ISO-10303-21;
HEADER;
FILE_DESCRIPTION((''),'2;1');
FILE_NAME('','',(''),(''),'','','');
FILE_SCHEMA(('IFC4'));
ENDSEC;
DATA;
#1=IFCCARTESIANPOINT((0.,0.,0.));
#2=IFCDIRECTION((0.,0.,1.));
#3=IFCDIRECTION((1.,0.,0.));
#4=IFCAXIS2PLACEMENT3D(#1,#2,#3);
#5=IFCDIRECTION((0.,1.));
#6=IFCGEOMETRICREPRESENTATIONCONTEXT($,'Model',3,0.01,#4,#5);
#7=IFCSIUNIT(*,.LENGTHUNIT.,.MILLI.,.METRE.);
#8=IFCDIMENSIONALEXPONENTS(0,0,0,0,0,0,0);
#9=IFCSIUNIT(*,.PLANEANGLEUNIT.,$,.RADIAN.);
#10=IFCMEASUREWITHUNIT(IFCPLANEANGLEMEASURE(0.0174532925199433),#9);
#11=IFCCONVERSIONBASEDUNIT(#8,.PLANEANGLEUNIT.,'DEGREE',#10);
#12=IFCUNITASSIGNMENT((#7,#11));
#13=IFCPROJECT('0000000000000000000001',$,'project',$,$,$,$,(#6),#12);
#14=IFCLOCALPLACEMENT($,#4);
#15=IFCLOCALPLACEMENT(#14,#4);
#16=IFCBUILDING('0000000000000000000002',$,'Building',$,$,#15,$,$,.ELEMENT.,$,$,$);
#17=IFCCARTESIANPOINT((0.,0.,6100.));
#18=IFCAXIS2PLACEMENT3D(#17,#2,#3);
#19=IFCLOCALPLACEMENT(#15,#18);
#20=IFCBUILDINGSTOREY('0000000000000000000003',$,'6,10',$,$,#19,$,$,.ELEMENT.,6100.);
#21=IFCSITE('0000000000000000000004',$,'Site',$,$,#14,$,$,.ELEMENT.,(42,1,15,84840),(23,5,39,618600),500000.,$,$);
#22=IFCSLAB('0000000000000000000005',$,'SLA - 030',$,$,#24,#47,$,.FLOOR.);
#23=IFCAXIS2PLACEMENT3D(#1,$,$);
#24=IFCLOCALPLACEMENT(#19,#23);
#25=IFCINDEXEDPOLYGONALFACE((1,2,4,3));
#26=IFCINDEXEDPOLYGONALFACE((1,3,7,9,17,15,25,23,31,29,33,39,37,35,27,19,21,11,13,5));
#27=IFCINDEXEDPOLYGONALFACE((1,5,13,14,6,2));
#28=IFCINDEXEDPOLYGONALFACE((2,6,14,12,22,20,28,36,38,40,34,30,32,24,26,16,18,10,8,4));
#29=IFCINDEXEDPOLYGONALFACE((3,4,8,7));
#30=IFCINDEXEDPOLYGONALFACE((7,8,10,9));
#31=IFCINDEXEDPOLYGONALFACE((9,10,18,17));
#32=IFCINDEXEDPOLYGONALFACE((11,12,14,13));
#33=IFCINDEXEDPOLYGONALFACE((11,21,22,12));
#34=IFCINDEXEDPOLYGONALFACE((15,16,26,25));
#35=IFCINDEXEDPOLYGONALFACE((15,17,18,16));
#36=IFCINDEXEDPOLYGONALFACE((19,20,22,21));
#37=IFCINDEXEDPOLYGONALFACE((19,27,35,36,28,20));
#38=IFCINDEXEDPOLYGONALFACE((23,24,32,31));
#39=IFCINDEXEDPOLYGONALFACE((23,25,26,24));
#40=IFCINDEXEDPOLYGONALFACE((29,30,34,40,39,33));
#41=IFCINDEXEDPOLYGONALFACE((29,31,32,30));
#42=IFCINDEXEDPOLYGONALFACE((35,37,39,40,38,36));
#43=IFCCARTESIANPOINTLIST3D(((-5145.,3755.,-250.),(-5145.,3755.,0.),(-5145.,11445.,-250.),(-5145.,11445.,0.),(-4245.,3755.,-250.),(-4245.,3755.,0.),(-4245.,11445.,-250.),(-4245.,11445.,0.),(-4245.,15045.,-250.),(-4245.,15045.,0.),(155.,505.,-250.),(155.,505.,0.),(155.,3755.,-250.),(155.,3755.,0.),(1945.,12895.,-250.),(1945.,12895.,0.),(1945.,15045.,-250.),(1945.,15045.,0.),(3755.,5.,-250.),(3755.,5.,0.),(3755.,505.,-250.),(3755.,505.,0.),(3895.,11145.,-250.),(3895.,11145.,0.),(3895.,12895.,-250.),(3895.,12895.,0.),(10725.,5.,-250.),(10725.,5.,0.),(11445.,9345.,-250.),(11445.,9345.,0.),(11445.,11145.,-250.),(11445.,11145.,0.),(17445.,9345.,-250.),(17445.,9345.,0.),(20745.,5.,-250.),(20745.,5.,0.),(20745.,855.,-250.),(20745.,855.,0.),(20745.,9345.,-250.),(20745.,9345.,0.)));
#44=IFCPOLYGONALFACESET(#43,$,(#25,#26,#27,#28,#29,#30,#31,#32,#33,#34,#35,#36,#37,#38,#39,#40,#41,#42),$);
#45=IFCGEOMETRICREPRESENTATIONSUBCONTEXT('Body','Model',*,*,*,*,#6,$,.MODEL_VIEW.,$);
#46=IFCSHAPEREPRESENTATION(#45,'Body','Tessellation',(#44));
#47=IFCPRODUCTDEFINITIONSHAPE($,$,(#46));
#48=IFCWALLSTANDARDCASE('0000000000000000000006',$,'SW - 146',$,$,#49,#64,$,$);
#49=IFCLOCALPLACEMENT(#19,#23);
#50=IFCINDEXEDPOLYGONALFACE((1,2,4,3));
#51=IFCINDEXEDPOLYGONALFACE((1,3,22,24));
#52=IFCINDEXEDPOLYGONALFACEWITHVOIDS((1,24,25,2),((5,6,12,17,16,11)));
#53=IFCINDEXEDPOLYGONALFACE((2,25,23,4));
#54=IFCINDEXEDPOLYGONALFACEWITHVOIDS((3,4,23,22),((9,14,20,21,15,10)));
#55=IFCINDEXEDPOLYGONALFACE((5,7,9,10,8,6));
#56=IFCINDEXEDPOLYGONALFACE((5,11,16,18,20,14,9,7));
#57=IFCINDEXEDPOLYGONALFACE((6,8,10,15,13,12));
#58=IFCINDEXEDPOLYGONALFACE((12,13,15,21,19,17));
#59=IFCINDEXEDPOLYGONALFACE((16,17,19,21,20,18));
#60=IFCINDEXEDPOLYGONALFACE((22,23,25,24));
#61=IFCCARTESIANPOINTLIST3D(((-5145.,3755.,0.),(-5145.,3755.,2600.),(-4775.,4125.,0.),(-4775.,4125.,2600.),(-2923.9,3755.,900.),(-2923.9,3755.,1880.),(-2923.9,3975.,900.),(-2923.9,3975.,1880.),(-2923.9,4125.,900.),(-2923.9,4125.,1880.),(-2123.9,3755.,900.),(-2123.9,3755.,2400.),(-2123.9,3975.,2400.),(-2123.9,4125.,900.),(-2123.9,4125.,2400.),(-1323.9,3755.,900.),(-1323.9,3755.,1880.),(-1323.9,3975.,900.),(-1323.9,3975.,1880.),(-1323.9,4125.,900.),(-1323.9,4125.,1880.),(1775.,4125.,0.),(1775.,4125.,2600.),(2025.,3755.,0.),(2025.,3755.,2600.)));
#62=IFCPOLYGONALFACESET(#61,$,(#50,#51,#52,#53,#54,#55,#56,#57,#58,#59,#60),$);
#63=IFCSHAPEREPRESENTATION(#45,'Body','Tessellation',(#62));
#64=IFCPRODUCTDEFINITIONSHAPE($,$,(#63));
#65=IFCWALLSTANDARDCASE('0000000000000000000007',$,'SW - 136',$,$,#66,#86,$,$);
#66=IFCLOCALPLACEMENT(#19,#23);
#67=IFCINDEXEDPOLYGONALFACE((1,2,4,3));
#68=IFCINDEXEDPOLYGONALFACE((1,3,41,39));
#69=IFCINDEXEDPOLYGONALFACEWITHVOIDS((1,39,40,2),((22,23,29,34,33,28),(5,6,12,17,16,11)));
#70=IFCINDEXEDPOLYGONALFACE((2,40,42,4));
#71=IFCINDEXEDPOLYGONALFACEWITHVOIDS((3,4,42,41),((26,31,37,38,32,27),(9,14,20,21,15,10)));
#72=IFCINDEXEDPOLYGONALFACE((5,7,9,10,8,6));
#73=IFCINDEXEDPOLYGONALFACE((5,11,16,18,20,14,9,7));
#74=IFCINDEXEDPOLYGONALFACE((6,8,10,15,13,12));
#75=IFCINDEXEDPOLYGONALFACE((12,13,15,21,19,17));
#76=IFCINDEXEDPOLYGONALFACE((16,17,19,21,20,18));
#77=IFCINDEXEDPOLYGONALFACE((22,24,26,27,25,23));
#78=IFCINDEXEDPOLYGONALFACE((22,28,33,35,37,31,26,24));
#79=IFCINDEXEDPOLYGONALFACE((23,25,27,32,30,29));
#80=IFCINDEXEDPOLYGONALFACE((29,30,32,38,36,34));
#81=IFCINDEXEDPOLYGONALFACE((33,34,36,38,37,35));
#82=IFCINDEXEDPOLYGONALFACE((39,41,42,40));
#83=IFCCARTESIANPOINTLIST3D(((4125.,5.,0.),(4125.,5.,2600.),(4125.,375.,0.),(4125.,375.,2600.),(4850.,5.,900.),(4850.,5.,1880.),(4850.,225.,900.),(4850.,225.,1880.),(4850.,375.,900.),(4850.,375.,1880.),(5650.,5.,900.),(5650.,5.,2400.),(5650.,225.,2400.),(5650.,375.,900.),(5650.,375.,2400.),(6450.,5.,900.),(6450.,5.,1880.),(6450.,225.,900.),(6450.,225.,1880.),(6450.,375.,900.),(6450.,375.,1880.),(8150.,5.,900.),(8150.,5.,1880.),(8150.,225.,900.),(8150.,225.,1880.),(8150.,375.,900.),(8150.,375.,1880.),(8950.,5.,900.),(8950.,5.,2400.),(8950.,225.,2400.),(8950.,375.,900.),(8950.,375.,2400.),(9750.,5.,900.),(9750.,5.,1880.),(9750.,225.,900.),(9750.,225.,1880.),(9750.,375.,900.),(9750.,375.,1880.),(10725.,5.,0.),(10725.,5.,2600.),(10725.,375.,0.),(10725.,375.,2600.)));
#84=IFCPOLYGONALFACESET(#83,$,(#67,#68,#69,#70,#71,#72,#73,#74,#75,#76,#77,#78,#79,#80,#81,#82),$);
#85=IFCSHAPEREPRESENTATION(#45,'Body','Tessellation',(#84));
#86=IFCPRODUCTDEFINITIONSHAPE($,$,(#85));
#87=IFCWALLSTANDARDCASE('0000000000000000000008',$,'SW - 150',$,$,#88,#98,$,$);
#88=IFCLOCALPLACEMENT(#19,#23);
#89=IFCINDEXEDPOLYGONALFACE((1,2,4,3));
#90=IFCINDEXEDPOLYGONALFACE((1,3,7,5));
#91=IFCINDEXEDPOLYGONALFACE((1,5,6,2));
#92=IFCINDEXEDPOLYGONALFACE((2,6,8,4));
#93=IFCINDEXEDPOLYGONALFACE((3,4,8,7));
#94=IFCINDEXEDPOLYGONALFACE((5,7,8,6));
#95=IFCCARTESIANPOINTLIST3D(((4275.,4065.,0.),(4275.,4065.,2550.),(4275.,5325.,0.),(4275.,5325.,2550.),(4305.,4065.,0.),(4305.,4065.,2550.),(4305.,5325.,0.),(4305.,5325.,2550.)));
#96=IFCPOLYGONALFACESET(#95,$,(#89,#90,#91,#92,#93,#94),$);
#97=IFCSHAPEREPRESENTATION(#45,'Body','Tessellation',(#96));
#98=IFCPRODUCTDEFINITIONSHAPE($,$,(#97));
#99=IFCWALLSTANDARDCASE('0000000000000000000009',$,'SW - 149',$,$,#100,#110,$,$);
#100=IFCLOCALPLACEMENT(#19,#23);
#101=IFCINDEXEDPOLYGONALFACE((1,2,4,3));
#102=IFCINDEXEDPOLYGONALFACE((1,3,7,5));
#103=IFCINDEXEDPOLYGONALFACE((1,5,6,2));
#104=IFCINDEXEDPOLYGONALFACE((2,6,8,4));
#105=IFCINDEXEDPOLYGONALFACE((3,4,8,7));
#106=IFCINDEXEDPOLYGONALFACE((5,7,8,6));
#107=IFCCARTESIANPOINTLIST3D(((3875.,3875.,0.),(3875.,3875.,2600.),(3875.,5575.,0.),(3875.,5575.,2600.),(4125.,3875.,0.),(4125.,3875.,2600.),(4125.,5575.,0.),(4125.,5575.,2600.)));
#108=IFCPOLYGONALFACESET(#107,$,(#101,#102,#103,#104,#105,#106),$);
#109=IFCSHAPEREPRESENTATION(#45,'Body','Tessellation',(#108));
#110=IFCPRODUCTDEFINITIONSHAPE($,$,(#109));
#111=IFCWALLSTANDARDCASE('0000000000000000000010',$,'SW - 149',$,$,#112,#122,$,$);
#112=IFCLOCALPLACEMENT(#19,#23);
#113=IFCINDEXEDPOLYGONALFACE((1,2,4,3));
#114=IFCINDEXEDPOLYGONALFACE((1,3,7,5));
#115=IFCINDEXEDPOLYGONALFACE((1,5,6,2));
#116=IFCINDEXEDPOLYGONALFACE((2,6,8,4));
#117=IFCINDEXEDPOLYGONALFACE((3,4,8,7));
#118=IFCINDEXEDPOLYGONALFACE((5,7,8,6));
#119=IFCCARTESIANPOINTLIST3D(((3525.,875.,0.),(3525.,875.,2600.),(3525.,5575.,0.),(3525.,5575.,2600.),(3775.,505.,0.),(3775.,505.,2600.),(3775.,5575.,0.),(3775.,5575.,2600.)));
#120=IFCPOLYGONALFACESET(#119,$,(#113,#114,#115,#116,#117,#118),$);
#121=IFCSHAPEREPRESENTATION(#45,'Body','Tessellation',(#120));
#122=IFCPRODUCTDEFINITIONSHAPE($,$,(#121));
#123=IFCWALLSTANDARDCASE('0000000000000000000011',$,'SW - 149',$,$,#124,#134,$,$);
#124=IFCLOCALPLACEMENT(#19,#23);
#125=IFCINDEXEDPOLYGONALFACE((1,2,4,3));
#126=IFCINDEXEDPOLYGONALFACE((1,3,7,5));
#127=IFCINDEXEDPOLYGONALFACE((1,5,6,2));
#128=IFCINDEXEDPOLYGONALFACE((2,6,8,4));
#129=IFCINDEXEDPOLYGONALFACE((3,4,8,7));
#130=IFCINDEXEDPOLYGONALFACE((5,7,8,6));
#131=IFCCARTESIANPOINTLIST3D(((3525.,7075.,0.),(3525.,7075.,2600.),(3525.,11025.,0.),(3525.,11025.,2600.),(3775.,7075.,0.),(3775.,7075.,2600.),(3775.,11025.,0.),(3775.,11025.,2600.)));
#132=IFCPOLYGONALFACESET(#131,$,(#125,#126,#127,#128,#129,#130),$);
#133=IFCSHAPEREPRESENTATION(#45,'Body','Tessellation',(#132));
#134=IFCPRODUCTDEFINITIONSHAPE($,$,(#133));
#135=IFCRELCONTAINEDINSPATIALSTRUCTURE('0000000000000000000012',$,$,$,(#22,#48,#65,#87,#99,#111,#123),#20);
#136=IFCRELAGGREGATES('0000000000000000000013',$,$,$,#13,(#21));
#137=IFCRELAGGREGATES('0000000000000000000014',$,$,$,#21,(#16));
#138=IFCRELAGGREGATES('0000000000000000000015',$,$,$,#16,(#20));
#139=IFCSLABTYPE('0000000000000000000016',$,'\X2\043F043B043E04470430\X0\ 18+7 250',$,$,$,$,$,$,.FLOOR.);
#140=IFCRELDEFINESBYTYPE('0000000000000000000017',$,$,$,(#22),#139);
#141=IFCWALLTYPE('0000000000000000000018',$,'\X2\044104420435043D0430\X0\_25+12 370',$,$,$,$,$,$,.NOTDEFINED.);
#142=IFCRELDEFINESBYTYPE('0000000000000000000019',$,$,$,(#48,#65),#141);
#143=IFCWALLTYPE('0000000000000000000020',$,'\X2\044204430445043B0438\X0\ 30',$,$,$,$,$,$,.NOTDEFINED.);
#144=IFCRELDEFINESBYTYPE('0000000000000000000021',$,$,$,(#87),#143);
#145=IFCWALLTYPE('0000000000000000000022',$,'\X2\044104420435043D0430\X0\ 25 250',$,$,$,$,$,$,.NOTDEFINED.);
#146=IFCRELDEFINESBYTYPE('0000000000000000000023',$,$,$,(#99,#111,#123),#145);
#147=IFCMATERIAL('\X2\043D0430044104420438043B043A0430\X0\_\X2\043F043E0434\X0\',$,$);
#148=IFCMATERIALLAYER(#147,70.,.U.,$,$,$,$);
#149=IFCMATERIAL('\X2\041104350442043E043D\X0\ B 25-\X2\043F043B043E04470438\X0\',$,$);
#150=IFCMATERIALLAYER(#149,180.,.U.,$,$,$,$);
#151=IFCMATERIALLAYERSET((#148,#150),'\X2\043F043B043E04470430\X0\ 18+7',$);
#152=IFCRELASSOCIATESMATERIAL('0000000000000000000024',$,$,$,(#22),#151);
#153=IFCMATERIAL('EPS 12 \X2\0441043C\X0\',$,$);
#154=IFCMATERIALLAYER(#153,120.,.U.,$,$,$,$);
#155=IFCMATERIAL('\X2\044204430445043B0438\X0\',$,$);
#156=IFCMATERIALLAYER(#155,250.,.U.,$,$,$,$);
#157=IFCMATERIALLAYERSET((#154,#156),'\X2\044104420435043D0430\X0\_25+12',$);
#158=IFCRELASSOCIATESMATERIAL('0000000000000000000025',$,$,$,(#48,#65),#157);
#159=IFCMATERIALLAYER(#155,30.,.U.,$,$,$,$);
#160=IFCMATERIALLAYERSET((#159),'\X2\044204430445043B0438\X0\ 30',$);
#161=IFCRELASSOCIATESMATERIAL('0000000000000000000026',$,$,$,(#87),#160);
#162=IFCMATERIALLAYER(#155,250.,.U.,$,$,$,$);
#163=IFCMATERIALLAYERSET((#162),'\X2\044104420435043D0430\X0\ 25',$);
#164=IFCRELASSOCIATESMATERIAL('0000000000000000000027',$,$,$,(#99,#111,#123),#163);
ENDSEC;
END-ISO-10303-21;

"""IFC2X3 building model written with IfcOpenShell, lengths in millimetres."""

from ifc_helpers import new_model, entity, si_unit, converted_unit, direction, frame, origin_with_axes, place, context, subcontext, project, spatial, polyline, outline, extrude, material, layer, layer_set, layer_usage, type_object, element, save


model = new_model("IFC2X3")

# Units and contexts
model_context = context("Model", 3, precision=0.01, world=origin_with_axes(), true_north=direction((0.0, 1.0)))
body_context = subcontext(model_context, "Body", "Model", "MODEL_VIEW")
ifc_project = project(units=[si_unit("LENGTHUNIT", "METRE", prefix="MILLI"), converted_unit("PLANEANGLEUNIT", "DEGREE", entity("IfcPlaneAngleMeasure", 0.0174532925199433), si_unit("PLANEANGLEUNIT", "RADIAN"), dimensions=[0, 0, 0, 0, 0, 0, 0])], contexts=[model_context])

# Site, building, storey
site_placement = place(None, origin_with_axes())
site = spatial("IfcSite", under=ifc_project, at=site_placement, Name="Site", CompositionType="ELEMENT", RefLatitude=(42, 1, 15, 84840), RefLongitude=(23, 5, 39, 618600), RefElevation=500000.0)
building_placement = place(site_placement, origin_with_axes())
building = spatial("IfcBuilding", under=site, at=building_placement, Name="Building", CompositionType="ELEMENT")
storey_placement = place(building_placement, frame((0.0, 0.0, 6100.0), z_axis=(0.0, 0.0, 1.0), x_axis=(1.0, 0.0, 0.0)))
storey = spatial("IfcBuildingStorey", under=building, at=storey_placement, Name="6,10", CompositionType="ELEMENT", Elevation=6100.0)

# Slab
ifc_material_1 = material(Name="настилка_под")
ifc_layer_1 = layer(ifc_material_1, 70.0, ventilated="UNKNOWN")
ifc_material_2 = material(Name="Бетон B 25-плочи")
ifc_layer_2 = layer(ifc_material_2, 180.0, ventilated="UNKNOWN")
ifc_layer_set_1 = layer_set([ifc_layer_1, ifc_layer_2], Name="плоча 18+7")
ifc_layer_usage_1 = layer_usage(ifc_layer_set_1, "AXIS3", "NEGATIVE", 250.0)
slab_type_1 = type_object("IfcSlabType", Name="плоча 18+7 250", PredefinedType="FLOOR")
slab_1_placement = place(storey_placement, frame((-5145.0, 3755.0, 0.0), z_axis=(0.0, 0.0, 1.0), x_axis=(1.0, 0.0, 0.0)))
element("IfcSlab", 1, at=slab_1_placement, inside=storey, type_object=slab_type_1, material=ifc_layer_usage_1, Name="SLA - 030", PredefinedType="FLOOR", context=body_context, shape_type="SweptSolid", body=[
    extrude(outline(polyline([(0.0, 0.0), (900.0, 0.0), (5300.0, 0.0), (5300.0, -3250.0), (8900.0, -3250.0), (8900.0, -3750.0), (15870.0, -3750.0), (25890.0, -3750.0), (25890.0, -2900.0), (25890.0, 5590.0), (22590.0, 5590.0), (16590.0, 5590.0), (16590.0, 7390.0), (9040.0, 7390.0), (9040.0, 9140.0), (7090.0, 9140.0), (7090.0, 11290.0), (900.0, 11290.0), (900.0, 7690.0), (0.0, 7690.0), (0.0, 0.0)])), frame((0.0, 0.0, -250.0), z_axis=(0.0, 0.0, 1.0), x_axis=(1.0, 0.0, 0.0)), (0.0, 0.0, 1.0), 250.0),
])

# Walls, openings
ifc_material_3 = material(Name="EPS 12 см")
ifc_layer_3 = layer(ifc_material_3, 120.0, ventilated="UNKNOWN")
ifc_material_4 = material(Name="тухли")
ifc_layer_4 = layer(ifc_material_4, 250.0, ventilated="UNKNOWN")
ifc_layer_set_2 = layer_set([ifc_layer_3, ifc_layer_4], Name="стена_25+12")
ifc_layer_usage_2 = layer_usage(ifc_layer_set_2, "AXIS2", "POSITIVE", -120.0)
wall_type_1 = type_object("IfcWallType", Name="стена_25+12 370", PredefinedType="NOTDEFINED")
wall_1_placement = place(storey_placement, frame((-5025.0, 3875.0, 0.0), z_axis=(0.0, 0.0, 1.0), x_axis=(1.0, 0.0, 0.0)))
wall_1 = element("IfcWallStandardCase", 2, at=wall_1_placement, inside=storey, type_object=wall_type_1, material=ifc_layer_usage_2, Name="SW - 146", context=body_context, shape_type="SweptSolid", body=[
    extrude(outline(polyline([(-120.0, -120.0), (7050.0, -120.0), (6800.0, 250.0), (250.0, 250.0), (-120.0, -120.0)])), origin_with_axes(), (0.0, 0.0, 1.0), 2600.0),
])
opening_1_placement = place(wall_1_placement, frame((2501.1, 0.0, 900.0), z_axis=(0.0, 0.0, 1.0), x_axis=(1.0, 0.0, 0.0)))
element("IfcOpeningElement", 3, at=opening_1_placement, cuts=wall_1, context=body_context, shape_type="SweptSolid", body=[
    extrude(outline(polyline([(-400.0, 0.0), (-400.0, -1500.0), (400.0, -980.0), (400.0, 0.0), (-400.0, 0.0)])), frame((0.0, 100.0, 0.0), z_axis=(0.0, -1.0, 0.0), x_axis=(-1.0, 0.0, 0.0)), (0.0, 0.0, 1.0), 590.0),
    extrude(outline(polyline([(400.0, 0.0), (400.0, 980.0), (-400.0, 1500.0), (-400.0, 0.0), (400.0, 0.0)])), frame((0.0, 100.0, 0.0), z_axis=(0.0, 1.0, 0.0), x_axis=(-1.0, 0.0, 0.0)), (0.0, 0.0, 1.0), 520.0),
])
opening_2_placement = place(wall_1_placement, frame((3301.1, 0.0, 900.0), z_axis=(0.0, 0.0, 1.0), x_axis=(1.0, 0.0, 0.0)))
element("IfcOpeningElement", 4, at=opening_2_placement, cuts=wall_1, context=body_context, shape_type="SweptSolid", body=[
    extrude(outline(polyline([(-400.0, 0.0), (-400.0, -1500.0), (400.0, -980.0), (400.0, 0.0), (-400.0, 0.0)])), frame((0.0, 100.0, 0.0), z_axis=(0.0, 1.0, 0.0), x_axis=(1.0, 0.0, 0.0)), (0.0, 0.0, -1.0), 590.0),
    extrude(outline(polyline([(400.0, 0.0), (400.0, 980.0), (-400.0, 1500.0), (-400.0, 0.0), (400.0, 0.0)])), frame((0.0, 100.0, 0.0), z_axis=(0.0, -1.0, 0.0), x_axis=(1.0, 0.0, 0.0)), (0.0, 0.0, -1.0), 520.0),
])
ifc_layer_usage_3 = layer_usage(ifc_layer_set_2, "AXIS2", "POSITIVE", -120.0)
wall_2_placement = place(storey_placement, frame((3875.0, 125.0, 0.0), z_axis=(0.0, 0.0, 1.0), x_axis=(1.0, 0.0, 0.0)))
wall_2 = element("IfcWallStandardCase", 5, at=wall_2_placement, inside=storey, type_object=wall_type_1, material=ifc_layer_usage_3, Name="SW - 136", context=body_context, shape_type="SweptSolid", body=[
    extrude(outline(polyline([(250.0, -120.0), (6850.0, -120.0), (6850.0, 250.0), (250.0, 250.0), (250.0, -120.0)])), origin_with_axes(), (0.0, 0.0, 1.0), 2600.0),
])
opening_3_placement = place(wall_2_placement, frame((1375.0, 0.0, 900.0), z_axis=(0.0, 0.0, 1.0), x_axis=(1.0, 0.0, 0.0)))
element("IfcOpeningElement", 6, at=opening_3_placement, cuts=wall_2, context=body_context, shape_type="SweptSolid", body=[
    extrude(outline(polyline([(-400.0, 0.0), (-400.0, -1500.0), (400.0, -980.0), (400.0, 0.0), (-400.0, 0.0)])), frame((0.0, 100.0, 0.0), z_axis=(0.0, -1.0, 0.0), x_axis=(-1.0, 0.0, 0.0)), (0.0, 0.0, 1.0), 590.0),
    extrude(outline(polyline([(400.0, 0.0), (400.0, 980.0), (-400.0, 1500.0), (-400.0, 0.0), (400.0, 0.0)])), frame((0.0, 100.0, 0.0), z_axis=(0.0, 1.0, 0.0), x_axis=(-1.0, 0.0, 0.0)), (0.0, 0.0, 1.0), 520.0),
])
opening_4_placement = place(wall_2_placement, frame((2175.0, 0.0, 900.0), z_axis=(0.0, 0.0, 1.0), x_axis=(1.0, 0.0, 0.0)))
element("IfcOpeningElement", 7, at=opening_4_placement, cuts=wall_2, context=body_context, shape_type="SweptSolid", body=[
    extrude(outline(polyline([(-400.0, 0.0), (-400.0, -1500.0), (400.0, -980.0), (400.0, 0.0), (-400.0, 0.0)])), frame((0.0, 100.0, 0.0), z_axis=(0.0, 1.0, 0.0), x_axis=(1.0, 0.0, 0.0)), (0.0, 0.0, -1.0), 590.0),
    extrude(outline(polyline([(400.0, 0.0), (400.0, 980.0), (-400.0, 1500.0), (-400.0, 0.0), (400.0, 0.0)])), frame((0.0, 100.0, 0.0), z_axis=(0.0, -1.0, 0.0), x_axis=(1.0, 0.0, 0.0)), (0.0, 0.0, -1.0), 520.0),
])
opening_5_placement = place(wall_2_placement, frame((4675.0, 0.0, 900.0), z_axis=(0.0, 0.0, 1.0), x_axis=(1.0, 0.0, 0.0)))
element("IfcOpeningElement", 8, at=opening_5_placement, cuts=wall_2, context=body_context, shape_type="SweptSolid", body=[
    extrude(outline(polyline([(-400.0, 0.0), (-400.0, -1500.0), (400.0, -980.0), (400.0, 0.0), (-400.0, 0.0)])), frame((0.0, 100.0, 0.0), z_axis=(0.0, -1.0, 0.0), x_axis=(-1.0, 0.0, 0.0)), (0.0, 0.0, 1.0), 590.0),
    extrude(outline(polyline([(400.0, 0.0), (400.0, 980.0), (-400.0, 1500.0), (-400.0, 0.0), (400.0, 0.0)])), frame((0.0, 100.0, 0.0), z_axis=(0.0, 1.0, 0.0), x_axis=(-1.0, 0.0, 0.0)), (0.0, 0.0, 1.0), 520.0),
])
opening_6_placement = place(wall_2_placement, frame((5475.0, 0.0, 900.0), z_axis=(0.0, 0.0, 1.0), x_axis=(1.0, 0.0, 0.0)))
element("IfcOpeningElement", 9, at=opening_6_placement, cuts=wall_2, context=body_context, shape_type="SweptSolid", body=[
    extrude(outline(polyline([(-400.0, 0.0), (-400.0, -1500.0), (400.0, -980.0), (400.0, 0.0), (-400.0, 0.0)])), frame((0.0, 100.0, 0.0), z_axis=(0.0, 1.0, 0.0), x_axis=(1.0, 0.0, 0.0)), (0.0, 0.0, -1.0), 590.0),
    extrude(outline(polyline([(400.0, 0.0), (400.0, 980.0), (-400.0, 1500.0), (-400.0, 0.0), (400.0, 0.0)])), frame((0.0, 100.0, 0.0), z_axis=(0.0, -1.0, 0.0), x_axis=(1.0, 0.0, 0.0)), (0.0, 0.0, -1.0), 520.0),
])

# Walls
ifc_layer_5 = layer(ifc_material_4, 30.0, ventilated="UNKNOWN")
ifc_layer_set_3 = layer_set([ifc_layer_5], Name="тухли 30")
wall_type_2 = type_object("IfcWallType", Name="тухли 30", PredefinedType="NOTDEFINED")
ifc_layer_usage_4 = layer_usage(ifc_layer_set_3, "AXIS2", "POSITIVE", 0.0)
wall_3_placement = place(storey_placement, frame((4305.0, 4065.0, 0.0), z_axis=(0.0, 0.0, 1.0), x_axis=(0.0, 1.0, 0.0)))
element("IfcWallStandardCase", 10, at=wall_3_placement, inside=storey, type_object=wall_type_2, material=ifc_layer_usage_4, Name="SW - 150", context=body_context, shape_type="SweptSolid", body=[
    extrude(outline(polyline([(0.0, 0.0), (1260.0, 0.0), (1260.0, 30.0), (0.0, 30.0), (0.0, 0.0)])), origin_with_axes(), (0.0, 0.0, 1.0), 2550.0),
])
ifc_layer_6 = layer(ifc_material_4, 250.0, ventilated="UNKNOWN")
ifc_layer_set_4 = layer_set([ifc_layer_6], Name="стена 25")
ifc_layer_usage_5 = layer_usage(ifc_layer_set_4, "AXIS2", "POSITIVE", 0.0)
wall_type_3 = type_object("IfcWallType", Name="стена 25 250", PredefinedType="NOTDEFINED")
wall_4_placement = place(storey_placement, frame((3875.0, 5575.0, 0.0), z_axis=(0.0, 0.0, 1.0), x_axis=(0.0, -1.0, 0.0)))
element("IfcWallStandardCase", 11, at=wall_4_placement, inside=storey, type_object=wall_type_3, material=ifc_layer_usage_5, Name="SW - 149", context=body_context, shape_type="SweptSolid", body=[
    extrude(outline(polyline([(0.0, 0.0), (1700.0, 0.0), (1700.0, 250.0), (0.0, 250.0), (0.0, 0.0)])), origin_with_axes(), (0.0, 0.0, 1.0), 2600.0),
])
ifc_layer_usage_6 = layer_usage(ifc_layer_set_4, "AXIS2", "POSITIVE", 0.0)
wall_5_placement = place(storey_placement, frame((3525.0, 5575.0, 0.0), z_axis=(0.0, 0.0, 1.0), x_axis=(0.0, -1.0, 0.0)))
element("IfcWallStandardCase", 12, at=wall_5_placement, inside=storey, type_object=wall_type_3, material=ifc_layer_usage_6, Name="SW - 149", context=body_context, shape_type="SweptSolid", body=[
    extrude(outline(polyline([(0.0, 0.0), (4700.0, 0.0), (5070.0, 250.0), (0.0, 250.0), (0.0, 0.0)])), origin_with_axes(), (0.0, 0.0, 1.0), 2600.0),
])
ifc_layer_usage_7 = layer_usage(ifc_layer_set_4, "AXIS2", "NEGATIVE", 0.0)
wall_6_placement = place(storey_placement, frame((3525.0, 7075.0, 0.0), z_axis=(0.0, 0.0, 1.0), x_axis=(0.0, 1.0, 0.0)))
element("IfcWallStandardCase", 13, at=wall_6_placement, inside=storey, type_object=wall_type_3, material=ifc_layer_usage_7, Name="SW - 149", context=body_context, shape_type="SweptSolid", body=[
    extrude(outline(polyline([(0.0, -250.0), (3950.0, -250.0), (3950.0, 0.0), (0.0, 0.0), (0.0, -250.0)])), origin_with_axes(), (0.0, 0.0, 1.0), 2600.0),
])

save(model, "model.ifc")
